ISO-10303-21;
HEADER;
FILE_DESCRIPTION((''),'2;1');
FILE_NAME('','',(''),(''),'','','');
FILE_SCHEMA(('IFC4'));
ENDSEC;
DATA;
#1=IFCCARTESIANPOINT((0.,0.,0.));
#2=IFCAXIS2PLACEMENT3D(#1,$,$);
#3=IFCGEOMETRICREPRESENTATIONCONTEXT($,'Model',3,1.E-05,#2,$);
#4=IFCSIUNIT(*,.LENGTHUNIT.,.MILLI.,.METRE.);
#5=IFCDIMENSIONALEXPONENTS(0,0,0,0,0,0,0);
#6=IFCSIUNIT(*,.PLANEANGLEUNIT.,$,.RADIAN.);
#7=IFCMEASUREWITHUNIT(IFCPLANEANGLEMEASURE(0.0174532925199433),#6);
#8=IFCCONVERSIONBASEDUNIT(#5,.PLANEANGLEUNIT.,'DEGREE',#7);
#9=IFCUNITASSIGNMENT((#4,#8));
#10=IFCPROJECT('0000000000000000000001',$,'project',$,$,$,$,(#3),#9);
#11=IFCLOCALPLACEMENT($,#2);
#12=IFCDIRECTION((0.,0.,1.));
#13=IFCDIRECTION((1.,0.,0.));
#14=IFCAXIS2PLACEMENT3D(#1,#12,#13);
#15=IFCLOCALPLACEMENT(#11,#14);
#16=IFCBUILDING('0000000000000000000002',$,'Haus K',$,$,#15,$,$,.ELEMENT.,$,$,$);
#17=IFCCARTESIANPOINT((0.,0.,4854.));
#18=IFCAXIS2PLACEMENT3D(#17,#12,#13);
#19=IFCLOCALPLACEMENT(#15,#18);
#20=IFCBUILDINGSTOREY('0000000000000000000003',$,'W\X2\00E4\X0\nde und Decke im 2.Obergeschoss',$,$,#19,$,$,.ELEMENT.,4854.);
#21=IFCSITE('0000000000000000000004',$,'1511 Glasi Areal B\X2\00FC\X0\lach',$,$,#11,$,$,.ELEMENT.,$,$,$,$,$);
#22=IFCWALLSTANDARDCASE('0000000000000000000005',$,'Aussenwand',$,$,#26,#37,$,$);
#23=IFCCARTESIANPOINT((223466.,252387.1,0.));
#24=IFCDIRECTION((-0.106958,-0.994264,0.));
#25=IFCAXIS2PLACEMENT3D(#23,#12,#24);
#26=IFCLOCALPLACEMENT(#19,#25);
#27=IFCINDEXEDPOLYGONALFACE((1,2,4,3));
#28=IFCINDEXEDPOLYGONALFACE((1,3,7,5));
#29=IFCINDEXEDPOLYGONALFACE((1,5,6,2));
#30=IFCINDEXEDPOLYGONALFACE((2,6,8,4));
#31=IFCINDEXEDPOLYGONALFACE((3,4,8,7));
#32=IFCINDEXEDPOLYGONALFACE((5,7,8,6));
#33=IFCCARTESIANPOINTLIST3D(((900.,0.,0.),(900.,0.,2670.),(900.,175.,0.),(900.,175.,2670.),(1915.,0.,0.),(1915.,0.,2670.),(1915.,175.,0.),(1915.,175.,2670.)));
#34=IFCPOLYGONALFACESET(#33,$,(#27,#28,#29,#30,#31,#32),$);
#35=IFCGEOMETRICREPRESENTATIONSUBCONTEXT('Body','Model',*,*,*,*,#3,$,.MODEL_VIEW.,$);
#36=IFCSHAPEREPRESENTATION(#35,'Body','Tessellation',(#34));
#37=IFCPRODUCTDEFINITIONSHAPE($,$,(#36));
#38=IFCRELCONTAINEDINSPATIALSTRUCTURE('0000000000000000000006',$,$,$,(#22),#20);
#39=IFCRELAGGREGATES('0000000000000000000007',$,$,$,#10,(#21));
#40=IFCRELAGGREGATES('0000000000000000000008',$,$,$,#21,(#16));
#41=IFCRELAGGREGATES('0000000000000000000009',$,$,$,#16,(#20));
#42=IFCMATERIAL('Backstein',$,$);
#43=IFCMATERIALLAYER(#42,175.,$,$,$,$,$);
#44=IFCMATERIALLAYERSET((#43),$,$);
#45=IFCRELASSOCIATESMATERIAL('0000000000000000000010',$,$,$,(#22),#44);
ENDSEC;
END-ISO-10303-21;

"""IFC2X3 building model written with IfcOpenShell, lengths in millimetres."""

from ifc_helpers import new_model, entity, si_unit, converted_unit, frame, origin, origin_with_axes, place, context, subcontext, project, spatial, polyline, outline, extrude, material, layer, layer_set, layer_usage, element, save


model = new_model("IFC2X3")

# Units and contexts
model_context = context("Model", 3, precision=1e-05, world=origin())
body_context = subcontext(model_context, "Body", "Model", "MODEL_VIEW")
ifc_project = project(units=[si_unit("LENGTHUNIT", "METRE", prefix="MILLI"), converted_unit("PLANEANGLEUNIT", "DEGREE", entity("IfcPlaneAngleMeasure", 0.0174532925199433), si_unit("PLANEANGLEUNIT", "RADIAN"), dimensions=[0, 0, 0, 0, 0, 0, 0])], contexts=[model_context])

# Site, building, storey
site_placement = place(None, origin())
site = spatial("IfcSite", under=ifc_project, at=site_placement, Name="1511 Glasi Areal Bülach", CompositionType="ELEMENT")
building_placement = place(site_placement, origin_with_axes())
building = spatial("IfcBuilding", under=site, at=building_placement, Name="Haus K", CompositionType="ELEMENT")
storey_placement = place(building_placement, frame((0.0, 0.0, 4854.0), z_axis=(0.0, 0.0, 1.0), x_axis=(1.0, 0.0, 0.0)))
storey = spatial("IfcBuildingStorey", under=building, at=storey_placement, Name="Wände und Decke im 2.Obergeschoss", CompositionType="ELEMENT", Elevation=4854.0)

# Wall
ifc_material_1 = material(Name="Backstein")
ifc_layer_1 = layer(ifc_material_1, 175.0)
ifc_layer_set_1 = layer_set([ifc_layer_1])
ifc_layer_usage_1 = layer_usage(ifc_layer_set_1, "AXIS2", "POSITIVE", 0.0)
wall_1_placement = place(storey_placement, frame((223466.0, 252387.1, 0.0), z_axis=(0.0, 0.0, 1.0), x_axis=(-0.106958, -0.994264, 0.0)))
element("IfcWallStandardCase", 1, at=wall_1_placement, inside=storey, material=ifc_layer_usage_1, Name="Aussenwand", context=body_context, shape_type="SweptSolid", body=[
    extrude(outline(polyline([(900.0, 0.0), (1915.0, 0.0), (1915.0, 175.0), (900.0, 175.0), (900.0, 0.0)])), origin_with_axes(), (0.0, 0.0, 1.0), 2670.0),
])

save(model, "model.ifc")
